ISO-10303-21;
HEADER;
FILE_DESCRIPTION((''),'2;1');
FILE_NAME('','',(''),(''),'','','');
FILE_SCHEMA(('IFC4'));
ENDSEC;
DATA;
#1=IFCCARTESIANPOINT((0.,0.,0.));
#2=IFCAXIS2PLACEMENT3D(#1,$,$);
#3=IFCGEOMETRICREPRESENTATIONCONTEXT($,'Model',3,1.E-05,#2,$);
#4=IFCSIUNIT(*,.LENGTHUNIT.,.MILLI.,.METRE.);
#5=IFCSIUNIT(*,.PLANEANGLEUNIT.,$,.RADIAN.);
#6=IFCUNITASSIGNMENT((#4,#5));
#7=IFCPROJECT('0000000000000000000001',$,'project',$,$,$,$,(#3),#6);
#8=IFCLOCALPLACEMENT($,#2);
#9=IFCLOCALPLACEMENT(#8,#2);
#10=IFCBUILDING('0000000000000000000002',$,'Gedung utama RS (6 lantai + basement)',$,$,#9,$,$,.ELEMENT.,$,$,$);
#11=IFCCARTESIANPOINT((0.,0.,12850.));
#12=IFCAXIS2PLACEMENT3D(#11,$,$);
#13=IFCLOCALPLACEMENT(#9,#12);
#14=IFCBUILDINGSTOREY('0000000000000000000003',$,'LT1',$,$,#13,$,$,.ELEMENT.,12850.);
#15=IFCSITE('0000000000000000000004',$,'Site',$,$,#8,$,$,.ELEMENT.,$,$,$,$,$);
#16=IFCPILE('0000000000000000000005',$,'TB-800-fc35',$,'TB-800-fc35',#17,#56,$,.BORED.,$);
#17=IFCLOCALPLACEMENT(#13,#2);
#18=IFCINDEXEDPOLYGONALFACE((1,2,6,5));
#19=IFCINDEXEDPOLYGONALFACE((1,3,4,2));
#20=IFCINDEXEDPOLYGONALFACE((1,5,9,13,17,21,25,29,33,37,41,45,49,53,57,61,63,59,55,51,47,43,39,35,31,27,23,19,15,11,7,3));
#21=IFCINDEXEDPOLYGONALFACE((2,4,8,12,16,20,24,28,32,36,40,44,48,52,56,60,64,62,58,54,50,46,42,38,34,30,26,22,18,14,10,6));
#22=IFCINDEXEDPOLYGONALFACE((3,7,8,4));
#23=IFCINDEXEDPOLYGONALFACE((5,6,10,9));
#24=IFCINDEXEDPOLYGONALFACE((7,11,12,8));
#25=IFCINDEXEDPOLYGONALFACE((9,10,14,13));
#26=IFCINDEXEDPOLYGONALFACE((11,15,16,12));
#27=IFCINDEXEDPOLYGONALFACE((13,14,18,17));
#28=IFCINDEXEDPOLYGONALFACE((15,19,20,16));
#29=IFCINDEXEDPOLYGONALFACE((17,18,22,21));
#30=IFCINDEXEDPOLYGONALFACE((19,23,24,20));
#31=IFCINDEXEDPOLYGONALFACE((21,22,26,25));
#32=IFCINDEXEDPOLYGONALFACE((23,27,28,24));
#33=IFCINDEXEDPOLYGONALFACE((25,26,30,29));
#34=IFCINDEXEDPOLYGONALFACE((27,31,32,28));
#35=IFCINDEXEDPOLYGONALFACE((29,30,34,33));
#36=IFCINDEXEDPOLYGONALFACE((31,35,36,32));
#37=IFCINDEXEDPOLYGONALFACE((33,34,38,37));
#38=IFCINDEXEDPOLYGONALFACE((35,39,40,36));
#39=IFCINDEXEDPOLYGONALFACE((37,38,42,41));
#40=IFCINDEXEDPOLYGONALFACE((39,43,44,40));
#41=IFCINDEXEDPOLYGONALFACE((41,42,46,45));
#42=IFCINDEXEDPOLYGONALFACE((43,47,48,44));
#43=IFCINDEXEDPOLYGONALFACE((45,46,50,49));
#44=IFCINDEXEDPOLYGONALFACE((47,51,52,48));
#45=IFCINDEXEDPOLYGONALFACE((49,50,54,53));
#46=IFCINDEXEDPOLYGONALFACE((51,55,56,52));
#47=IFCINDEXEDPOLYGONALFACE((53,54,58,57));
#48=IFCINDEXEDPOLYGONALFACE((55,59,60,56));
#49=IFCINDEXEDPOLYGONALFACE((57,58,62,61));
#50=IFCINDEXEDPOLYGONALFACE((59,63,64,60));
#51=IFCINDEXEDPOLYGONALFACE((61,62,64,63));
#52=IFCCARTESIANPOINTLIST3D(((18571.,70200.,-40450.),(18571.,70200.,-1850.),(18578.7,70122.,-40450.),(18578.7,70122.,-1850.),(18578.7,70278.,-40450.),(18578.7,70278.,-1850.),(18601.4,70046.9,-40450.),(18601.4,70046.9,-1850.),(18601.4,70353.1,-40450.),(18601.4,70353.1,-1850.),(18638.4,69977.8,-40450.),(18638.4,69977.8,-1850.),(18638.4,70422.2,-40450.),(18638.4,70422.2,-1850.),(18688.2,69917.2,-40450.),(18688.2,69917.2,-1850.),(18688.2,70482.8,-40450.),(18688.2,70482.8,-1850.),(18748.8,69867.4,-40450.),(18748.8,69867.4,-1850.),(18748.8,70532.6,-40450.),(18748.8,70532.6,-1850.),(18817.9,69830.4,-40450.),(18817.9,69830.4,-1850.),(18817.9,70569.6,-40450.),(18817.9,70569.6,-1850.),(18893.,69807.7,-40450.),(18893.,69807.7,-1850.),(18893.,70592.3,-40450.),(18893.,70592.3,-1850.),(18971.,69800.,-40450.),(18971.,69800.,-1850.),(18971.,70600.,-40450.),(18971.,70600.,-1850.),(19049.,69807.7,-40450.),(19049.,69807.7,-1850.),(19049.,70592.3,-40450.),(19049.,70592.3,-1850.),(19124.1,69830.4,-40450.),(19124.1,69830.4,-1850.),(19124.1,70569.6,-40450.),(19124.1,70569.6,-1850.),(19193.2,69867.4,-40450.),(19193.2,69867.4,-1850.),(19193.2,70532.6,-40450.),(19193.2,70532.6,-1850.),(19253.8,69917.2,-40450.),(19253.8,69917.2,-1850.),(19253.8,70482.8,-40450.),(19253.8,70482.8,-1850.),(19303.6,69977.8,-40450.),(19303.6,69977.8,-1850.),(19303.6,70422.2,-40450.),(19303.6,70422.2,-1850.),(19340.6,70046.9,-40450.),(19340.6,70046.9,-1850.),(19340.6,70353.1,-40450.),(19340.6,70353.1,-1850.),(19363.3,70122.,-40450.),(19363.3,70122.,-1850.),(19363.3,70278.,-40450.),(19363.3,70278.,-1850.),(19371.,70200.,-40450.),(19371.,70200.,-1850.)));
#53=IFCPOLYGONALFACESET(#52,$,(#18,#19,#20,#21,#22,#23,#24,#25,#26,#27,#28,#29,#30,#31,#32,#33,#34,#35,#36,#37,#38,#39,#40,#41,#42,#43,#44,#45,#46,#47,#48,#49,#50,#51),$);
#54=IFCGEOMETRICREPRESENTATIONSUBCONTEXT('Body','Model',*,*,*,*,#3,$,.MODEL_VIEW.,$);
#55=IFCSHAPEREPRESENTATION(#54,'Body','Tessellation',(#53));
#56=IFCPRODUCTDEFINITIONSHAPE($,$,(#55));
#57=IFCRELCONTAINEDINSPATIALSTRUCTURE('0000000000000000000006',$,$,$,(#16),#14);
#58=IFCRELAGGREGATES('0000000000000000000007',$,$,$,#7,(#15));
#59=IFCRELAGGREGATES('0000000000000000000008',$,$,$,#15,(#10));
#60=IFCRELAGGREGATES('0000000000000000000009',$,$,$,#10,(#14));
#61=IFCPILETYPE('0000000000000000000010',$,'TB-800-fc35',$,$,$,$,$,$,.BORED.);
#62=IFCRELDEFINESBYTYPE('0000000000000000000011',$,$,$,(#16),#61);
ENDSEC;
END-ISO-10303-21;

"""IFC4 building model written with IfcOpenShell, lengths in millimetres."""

from ifc_helpers import new_model, si_unit, frame, origin, origin_2d, place, context, subcontext, project, spatial, circle, extrude, material_profile, profile_set, profile_usage, type_object, element, save


model = new_model("IFC4")

# Units and contexts
model_context = context("Model", 3, precision=1e-05, world=origin())
body_context = subcontext(model_context, "Body", "Model", "MODEL_VIEW")
ifc_project = project(units=[si_unit("LENGTHUNIT", "METRE", prefix="MILLI"), si_unit("PLANEANGLEUNIT", "RADIAN")], contexts=[model_context])

# Site, building, storey
site_placement = place(None, origin())
site = spatial("IfcSite", under=ifc_project, at=site_placement, Name="Site", CompositionType="ELEMENT")
building_placement = place(site_placement, origin())
building = spatial("IfcBuilding", under=site, at=building_placement, Name="Gedung utama RS (6 lantai + basement)", CompositionType="ELEMENT")
storey_placement = place(building_placement, frame((0.0, 0.0, 12850.0)))
storey = spatial("IfcBuildingStorey", under=building, at=storey_placement, Name="LT1", CompositionType="ELEMENT", Elevation=12850.0)

# Pile
ifc_material_profile = material_profile(None, circle(Radius=400.0, at=origin_2d()), Name="TB-800-fc35")
ifc_profile_set = profile_set([ifc_material_profile], Name="TB-800-fc35")
ifc_profile_usage = profile_usage(ifc_profile_set, cardinal=5)
pile_type = type_object("IfcPileType", Name="TB-800-fc35", PredefinedType="BORED", material=ifc_profile_set)
for number, where, z_axis, x_axis, name in (
    (1, (18971.0, 70200.0, -40450.0), (0.0, 0.0, 1.0), (1.0, 0.0, 0.0), "TB-800-fc35"),
):
    element("IfcPile", number, at=place(storey_placement, frame(where, z_axis=z_axis, x_axis=x_axis)), inside=storey, type_object=pile_type, material=ifc_profile_usage, Name=name, ObjectType="TB-800-fc35", PredefinedType="BORED", context=body_context, shape_type="SweptSolid", body=[
        extrude(circle(Radius=400.0, at=origin_2d()), origin(), (0.0, 0.0, 1.0), 38600.0),
    ])

save(model, "model.ifc")
